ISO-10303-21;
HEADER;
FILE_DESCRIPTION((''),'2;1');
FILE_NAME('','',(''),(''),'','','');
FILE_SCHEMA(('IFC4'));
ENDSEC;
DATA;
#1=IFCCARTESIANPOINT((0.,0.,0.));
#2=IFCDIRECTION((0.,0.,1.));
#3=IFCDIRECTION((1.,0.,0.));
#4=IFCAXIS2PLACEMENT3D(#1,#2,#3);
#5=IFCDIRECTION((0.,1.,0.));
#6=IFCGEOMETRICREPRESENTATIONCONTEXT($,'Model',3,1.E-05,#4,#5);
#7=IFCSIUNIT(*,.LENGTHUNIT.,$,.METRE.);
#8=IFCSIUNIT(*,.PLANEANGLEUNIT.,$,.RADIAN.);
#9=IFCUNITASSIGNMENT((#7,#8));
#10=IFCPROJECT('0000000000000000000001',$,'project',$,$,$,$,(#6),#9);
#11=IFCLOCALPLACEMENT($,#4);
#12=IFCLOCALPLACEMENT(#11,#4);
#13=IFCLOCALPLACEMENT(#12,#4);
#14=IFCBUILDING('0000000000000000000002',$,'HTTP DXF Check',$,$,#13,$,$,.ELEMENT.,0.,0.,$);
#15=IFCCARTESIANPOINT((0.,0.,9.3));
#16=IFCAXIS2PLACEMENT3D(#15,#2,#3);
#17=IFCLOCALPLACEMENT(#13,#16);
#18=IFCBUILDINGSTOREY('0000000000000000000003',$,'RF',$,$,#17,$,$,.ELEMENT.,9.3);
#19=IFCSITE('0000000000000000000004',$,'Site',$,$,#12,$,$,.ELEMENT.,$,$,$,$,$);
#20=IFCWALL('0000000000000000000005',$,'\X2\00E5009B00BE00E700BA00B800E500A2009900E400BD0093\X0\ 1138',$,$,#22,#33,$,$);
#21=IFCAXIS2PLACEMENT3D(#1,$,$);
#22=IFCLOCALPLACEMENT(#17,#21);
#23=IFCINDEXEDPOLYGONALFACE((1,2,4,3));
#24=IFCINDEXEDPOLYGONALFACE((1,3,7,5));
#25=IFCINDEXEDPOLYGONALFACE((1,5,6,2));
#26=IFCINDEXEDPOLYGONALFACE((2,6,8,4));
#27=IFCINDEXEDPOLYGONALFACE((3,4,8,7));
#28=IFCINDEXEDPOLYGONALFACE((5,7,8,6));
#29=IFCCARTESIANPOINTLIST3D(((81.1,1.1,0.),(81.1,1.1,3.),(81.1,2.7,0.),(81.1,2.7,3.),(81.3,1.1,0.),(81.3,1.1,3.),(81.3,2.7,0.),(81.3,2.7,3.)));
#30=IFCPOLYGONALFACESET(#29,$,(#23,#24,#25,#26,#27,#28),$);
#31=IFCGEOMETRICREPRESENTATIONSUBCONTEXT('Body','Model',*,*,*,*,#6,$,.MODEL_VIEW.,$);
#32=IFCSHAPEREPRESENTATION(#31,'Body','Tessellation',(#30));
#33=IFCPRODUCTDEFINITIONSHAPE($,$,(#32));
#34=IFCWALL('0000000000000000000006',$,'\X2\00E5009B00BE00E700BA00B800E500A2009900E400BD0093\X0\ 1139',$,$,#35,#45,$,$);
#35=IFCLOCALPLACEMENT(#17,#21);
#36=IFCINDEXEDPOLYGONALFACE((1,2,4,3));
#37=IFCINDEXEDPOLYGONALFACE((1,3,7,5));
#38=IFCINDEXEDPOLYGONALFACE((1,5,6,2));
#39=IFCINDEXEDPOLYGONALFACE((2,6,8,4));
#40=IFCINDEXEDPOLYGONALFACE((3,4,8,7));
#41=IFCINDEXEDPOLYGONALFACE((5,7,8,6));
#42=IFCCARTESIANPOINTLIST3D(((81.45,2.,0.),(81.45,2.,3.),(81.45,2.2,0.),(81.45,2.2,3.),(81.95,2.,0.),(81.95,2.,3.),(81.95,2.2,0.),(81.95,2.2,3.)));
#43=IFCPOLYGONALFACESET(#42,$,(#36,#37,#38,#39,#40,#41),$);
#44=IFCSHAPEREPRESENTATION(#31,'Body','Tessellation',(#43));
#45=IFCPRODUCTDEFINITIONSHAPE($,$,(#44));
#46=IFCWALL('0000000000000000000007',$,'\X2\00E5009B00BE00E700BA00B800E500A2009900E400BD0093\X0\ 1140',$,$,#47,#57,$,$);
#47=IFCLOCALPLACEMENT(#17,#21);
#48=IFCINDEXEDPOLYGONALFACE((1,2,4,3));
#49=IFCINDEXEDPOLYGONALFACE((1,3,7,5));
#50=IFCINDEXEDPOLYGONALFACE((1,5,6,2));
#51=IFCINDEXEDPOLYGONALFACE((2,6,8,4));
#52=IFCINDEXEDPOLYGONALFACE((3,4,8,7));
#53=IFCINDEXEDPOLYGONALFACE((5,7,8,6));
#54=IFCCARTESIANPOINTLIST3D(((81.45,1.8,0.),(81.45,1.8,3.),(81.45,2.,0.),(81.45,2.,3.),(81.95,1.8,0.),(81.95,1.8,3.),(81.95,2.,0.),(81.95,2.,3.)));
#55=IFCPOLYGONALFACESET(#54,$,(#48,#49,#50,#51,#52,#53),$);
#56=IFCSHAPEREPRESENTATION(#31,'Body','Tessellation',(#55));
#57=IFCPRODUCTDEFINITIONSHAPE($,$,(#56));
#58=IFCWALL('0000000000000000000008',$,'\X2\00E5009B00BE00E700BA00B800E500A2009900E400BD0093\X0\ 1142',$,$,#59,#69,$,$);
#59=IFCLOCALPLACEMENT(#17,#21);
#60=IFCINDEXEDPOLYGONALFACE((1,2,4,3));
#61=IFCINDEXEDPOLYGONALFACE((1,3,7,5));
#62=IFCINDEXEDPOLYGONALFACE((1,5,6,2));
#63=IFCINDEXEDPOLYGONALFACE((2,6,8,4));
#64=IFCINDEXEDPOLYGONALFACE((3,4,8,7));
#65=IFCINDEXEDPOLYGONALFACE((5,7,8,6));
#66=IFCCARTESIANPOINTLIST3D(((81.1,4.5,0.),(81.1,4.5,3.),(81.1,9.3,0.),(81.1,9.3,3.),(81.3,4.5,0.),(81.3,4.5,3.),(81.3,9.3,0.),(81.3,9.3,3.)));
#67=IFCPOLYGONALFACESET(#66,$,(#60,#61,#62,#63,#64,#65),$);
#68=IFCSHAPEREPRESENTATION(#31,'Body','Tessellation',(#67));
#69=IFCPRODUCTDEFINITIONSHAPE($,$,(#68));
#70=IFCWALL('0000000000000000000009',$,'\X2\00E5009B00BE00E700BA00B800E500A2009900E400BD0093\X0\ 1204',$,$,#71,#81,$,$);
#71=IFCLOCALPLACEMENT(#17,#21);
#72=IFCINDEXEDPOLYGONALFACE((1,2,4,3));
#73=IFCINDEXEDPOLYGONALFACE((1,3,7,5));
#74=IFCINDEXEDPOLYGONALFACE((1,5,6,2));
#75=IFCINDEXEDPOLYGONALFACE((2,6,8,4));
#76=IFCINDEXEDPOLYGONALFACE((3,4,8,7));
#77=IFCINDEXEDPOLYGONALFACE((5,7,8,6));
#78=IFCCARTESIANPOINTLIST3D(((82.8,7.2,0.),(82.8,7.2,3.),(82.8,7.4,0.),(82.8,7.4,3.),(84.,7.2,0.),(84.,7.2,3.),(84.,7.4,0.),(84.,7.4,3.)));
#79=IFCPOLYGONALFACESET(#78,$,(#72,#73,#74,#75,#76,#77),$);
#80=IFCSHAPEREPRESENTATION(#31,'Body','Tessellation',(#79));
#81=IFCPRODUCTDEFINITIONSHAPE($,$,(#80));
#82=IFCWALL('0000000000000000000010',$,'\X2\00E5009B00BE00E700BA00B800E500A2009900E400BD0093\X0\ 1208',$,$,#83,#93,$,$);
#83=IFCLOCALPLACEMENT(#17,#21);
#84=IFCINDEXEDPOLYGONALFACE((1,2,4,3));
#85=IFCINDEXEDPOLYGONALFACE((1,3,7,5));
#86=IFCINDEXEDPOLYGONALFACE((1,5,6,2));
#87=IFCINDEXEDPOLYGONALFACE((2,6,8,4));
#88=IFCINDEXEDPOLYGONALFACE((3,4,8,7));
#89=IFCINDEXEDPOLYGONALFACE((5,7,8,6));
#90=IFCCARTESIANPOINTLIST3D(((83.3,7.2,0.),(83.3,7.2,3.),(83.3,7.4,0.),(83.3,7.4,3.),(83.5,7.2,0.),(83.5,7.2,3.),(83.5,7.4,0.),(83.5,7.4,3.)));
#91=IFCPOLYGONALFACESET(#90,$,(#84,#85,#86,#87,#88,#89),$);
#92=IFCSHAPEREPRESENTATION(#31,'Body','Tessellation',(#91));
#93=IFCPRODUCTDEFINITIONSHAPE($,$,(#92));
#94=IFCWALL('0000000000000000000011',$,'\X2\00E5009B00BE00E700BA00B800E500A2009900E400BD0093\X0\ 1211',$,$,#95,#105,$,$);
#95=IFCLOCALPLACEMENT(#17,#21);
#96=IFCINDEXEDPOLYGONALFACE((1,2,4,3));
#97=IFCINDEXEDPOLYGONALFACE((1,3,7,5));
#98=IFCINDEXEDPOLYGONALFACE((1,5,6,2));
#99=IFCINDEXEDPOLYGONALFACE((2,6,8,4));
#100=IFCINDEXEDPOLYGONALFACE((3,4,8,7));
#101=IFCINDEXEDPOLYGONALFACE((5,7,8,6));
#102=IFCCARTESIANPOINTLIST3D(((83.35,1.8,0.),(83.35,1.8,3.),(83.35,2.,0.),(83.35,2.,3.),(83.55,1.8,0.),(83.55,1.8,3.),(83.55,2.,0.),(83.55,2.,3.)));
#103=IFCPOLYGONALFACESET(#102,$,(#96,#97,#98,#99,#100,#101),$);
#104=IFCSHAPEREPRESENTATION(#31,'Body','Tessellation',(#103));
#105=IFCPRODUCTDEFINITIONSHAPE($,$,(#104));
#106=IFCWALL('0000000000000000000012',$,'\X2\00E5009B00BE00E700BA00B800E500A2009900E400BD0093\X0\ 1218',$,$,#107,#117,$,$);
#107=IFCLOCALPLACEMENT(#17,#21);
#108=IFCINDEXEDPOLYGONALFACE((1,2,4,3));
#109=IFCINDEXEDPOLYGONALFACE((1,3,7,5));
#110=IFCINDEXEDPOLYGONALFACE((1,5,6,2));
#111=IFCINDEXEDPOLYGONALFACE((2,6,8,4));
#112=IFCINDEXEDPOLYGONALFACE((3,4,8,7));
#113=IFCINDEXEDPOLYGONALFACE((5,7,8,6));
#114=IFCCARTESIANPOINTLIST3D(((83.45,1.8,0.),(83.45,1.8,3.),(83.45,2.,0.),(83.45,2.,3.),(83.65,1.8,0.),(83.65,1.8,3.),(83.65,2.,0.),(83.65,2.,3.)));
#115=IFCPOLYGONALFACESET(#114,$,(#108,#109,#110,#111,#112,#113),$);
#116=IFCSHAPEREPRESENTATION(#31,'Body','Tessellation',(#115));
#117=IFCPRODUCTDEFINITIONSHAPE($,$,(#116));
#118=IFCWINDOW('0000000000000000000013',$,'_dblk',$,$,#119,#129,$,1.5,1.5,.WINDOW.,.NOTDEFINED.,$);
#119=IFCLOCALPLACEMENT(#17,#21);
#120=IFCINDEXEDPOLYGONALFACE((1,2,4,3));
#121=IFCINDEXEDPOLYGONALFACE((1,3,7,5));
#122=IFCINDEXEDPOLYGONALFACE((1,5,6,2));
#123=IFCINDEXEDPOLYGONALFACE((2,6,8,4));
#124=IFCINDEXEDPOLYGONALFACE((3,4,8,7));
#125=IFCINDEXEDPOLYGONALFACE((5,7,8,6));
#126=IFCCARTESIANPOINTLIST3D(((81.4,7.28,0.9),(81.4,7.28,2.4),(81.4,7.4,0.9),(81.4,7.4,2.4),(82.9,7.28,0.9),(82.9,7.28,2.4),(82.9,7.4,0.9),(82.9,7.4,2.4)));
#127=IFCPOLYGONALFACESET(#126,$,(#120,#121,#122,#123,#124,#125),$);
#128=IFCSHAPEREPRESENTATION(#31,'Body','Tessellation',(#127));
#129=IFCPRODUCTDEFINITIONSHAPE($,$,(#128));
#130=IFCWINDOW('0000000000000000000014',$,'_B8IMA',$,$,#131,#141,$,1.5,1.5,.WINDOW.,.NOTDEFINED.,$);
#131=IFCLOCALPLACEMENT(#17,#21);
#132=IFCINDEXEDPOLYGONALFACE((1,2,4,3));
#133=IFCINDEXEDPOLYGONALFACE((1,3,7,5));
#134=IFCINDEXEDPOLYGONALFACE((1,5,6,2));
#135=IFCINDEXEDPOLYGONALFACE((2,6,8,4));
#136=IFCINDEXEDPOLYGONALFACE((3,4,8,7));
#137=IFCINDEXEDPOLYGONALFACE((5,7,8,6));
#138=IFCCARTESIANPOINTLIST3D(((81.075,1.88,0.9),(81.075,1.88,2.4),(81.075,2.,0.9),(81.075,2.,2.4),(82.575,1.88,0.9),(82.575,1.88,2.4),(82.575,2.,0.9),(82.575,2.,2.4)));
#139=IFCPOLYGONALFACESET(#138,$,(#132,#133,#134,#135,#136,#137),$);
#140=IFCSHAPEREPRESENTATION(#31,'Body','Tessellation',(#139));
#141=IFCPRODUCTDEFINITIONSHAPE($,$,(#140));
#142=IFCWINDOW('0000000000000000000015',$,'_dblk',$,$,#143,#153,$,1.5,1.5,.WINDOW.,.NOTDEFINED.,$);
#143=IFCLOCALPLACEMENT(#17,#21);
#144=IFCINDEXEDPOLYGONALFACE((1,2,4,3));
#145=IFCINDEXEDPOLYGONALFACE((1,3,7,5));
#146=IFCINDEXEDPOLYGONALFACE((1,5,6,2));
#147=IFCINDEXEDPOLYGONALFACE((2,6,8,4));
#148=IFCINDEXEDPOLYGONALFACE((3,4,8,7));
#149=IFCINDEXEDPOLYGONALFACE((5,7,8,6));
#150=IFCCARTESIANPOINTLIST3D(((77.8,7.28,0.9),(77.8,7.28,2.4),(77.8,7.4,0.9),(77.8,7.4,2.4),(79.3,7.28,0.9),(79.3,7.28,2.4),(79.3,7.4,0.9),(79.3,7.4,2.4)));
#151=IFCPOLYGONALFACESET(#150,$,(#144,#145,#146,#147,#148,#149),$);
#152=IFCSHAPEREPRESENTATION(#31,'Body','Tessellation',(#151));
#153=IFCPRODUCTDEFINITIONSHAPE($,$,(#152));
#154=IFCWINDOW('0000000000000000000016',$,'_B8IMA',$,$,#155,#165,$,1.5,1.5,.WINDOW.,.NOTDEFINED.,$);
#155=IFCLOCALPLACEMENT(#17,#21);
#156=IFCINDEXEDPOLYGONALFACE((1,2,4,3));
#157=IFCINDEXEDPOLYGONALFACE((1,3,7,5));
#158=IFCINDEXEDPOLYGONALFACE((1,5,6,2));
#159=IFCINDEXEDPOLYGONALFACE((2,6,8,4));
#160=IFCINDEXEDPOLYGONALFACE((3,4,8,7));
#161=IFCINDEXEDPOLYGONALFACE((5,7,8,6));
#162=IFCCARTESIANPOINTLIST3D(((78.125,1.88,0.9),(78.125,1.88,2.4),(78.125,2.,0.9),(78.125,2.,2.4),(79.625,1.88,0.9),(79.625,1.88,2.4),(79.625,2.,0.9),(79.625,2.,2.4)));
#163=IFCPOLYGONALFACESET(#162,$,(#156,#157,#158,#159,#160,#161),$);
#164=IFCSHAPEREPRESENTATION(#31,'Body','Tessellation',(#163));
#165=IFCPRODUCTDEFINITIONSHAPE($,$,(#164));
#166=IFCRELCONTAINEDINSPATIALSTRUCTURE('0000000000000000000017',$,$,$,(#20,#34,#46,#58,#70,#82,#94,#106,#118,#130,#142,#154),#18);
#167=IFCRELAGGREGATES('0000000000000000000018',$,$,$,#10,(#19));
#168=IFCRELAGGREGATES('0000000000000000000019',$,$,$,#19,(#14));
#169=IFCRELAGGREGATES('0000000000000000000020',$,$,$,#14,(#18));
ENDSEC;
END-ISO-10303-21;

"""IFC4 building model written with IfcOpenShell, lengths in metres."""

from ifc_helpers import new_model, si_unit, direction, frame, frame_2d, origin_with_axes, place, context, subcontext, project, spatial, rectangle, extrude, element, save


model = new_model("IFC4")

# Units and contexts
model_context = context("Model", 3, precision=1e-05, world=origin_with_axes(), true_north=direction((0.0, 1.0, 0.0)))
body_context = subcontext(model_context, "Body", "Model", "MODEL_VIEW")
ifc_project = project(units=[si_unit("LENGTHUNIT", "METRE"), si_unit("PLANEANGLEUNIT", "RADIAN")], contexts=[model_context])

# Site, building, storey
placement = place(None, origin_with_axes())
site_placement = place(placement, origin_with_axes())
site = spatial("IfcSite", under=ifc_project, at=site_placement, Name="Site", CompositionType="ELEMENT")
building_placement = place(site_placement, origin_with_axes())
building = spatial("IfcBuilding", under=site, at=building_placement, Name="HTTP DXF Check", CompositionType="ELEMENT", ElevationOfRefHeight=0.0, ElevationOfTerrain=0.0)
storey_placement = place(building_placement, frame((0.0, 0.0, 9.3), z_axis=(0.0, 0.0, 1.0), x_axis=(1.0, 0.0, 0.0)))
storey = spatial("IfcBuildingStorey", under=building, at=storey_placement, Name="RF", CompositionType="ELEMENT", Elevation=9.3)

# Walls
wall_1_placement = place(storey_placement, frame((81.2, 1.9, 0.0), z_axis=(0.0, 0.0, 1.0), x_axis=(0.0, -1.0, 0.0)))
element("IfcWall", 1, at=wall_1_placement, inside=storey, Name="å\u009b¾çº¸å¢\u0099ä½\u0093 1138", context=body_context, shape_type="SweptSolid", body=[
    extrude(rectangle(XDim=1.6, YDim=0.2, at=frame_2d((0.0, 0.0), x_axis=(1.0, 0.0, 0.0))), frame((0.0, 0.0, 0.0), z_axis=(0.0, 0.0, 1.0)), (0.0, 0.0, 1.0), 3.0),
])
for number, where, z_axis, x_axis, name in (
    (2, (81.7, 2.1, 0.0), (0.0, 0.0, 1.0), (-1.0, 0.0, 0.0), "å\u009b¾çº¸å¢\u0099ä½\u0093 1139"),
    (3, (81.7, 1.9, 0.0), (0.0, 0.0, 1.0), (-1.0, 0.0, 0.0), "å\u009b¾çº¸å¢\u0099ä½\u0093 1140"),
):
    element("IfcWall", number, at=place(storey_placement, frame(where, z_axis=z_axis, x_axis=x_axis)), inside=storey, Name=name, context=body_context, shape_type="SweptSolid", body=[
        extrude(rectangle(XDim=0.5, YDim=0.2, at=frame_2d((0.0, 0.0), x_axis=(1.0, 0.0, 0.0))), frame((0.0, 0.0, 0.0), z_axis=(0.0, 0.0, 1.0)), (0.0, 0.0, 1.0), 3.0),
    ])
wall_2_placement = place(storey_placement, frame((81.2, 6.9, 0.0), z_axis=(0.0, 0.0, 1.0), x_axis=(0.0, -1.0, 0.0)))
element("IfcWall", 4, at=wall_2_placement, inside=storey, Name="å\u009b¾çº¸å¢\u0099ä½\u0093 1142", context=body_context, shape_type="SweptSolid", body=[
    extrude(rectangle(XDim=4.8, YDim=0.2, at=frame_2d((0.0, 0.0), x_axis=(1.0, 0.0, 0.0))), frame((0.0, 0.0, 0.0), z_axis=(0.0, 0.0, 1.0)), (0.0, 0.0, 1.0), 3.0),
])
wall_3_placement = place(storey_placement, frame((83.4, 7.3, 0.0), z_axis=(0.0, 0.0, 1.0), x_axis=(1.0, 0.0, 0.0)))
element("IfcWall", 5, at=wall_3_placement, inside=storey, Name="å\u009b¾çº¸å¢\u0099ä½\u0093 1204", context=body_context, shape_type="SweptSolid", body=[
    extrude(rectangle(XDim=1.2, YDim=0.2, at=frame_2d((0.0, 0.0), x_axis=(1.0, 0.0, 0.0))), frame((0.0, 0.0, 0.0), z_axis=(0.0, 0.0, 1.0)), (0.0, 0.0, 1.0), 3.0),
])
for number, where, z_axis, x_axis, name in (
    (6, (83.4, 7.3, 0.0), (0.0, 0.0, 1.0), (0.0, 1.0, 0.0), "å\u009b¾çº¸å¢\u0099ä½\u0093 1208"),
    (7, (83.45, 1.9, 0.0), (0.0, 0.0, 1.0), (0.0, 1.0, 0.0), "å\u009b¾çº¸å¢\u0099ä½\u0093 1211"),
    (8, (83.55, 1.9, 0.0), (0.0, 0.0, 1.0), (0.0, -1.0, 0.0), "å\u009b¾çº¸å¢\u0099ä½\u0093 1218"),
):
    element("IfcWall", number, at=place(storey_placement, frame(where, z_axis=z_axis, x_axis=x_axis)), inside=storey, Name=name, context=body_context, shape_type="SweptSolid", body=[
        extrude(rectangle(XDim=0.2, YDim=0.2, at=frame_2d((0.0, 0.0), x_axis=(1.0, 0.0, 0.0))), frame((0.0, 0.0, 0.0), z_axis=(0.0, 0.0, 1.0)), (0.0, 0.0, 1.0), 3.0),
    ])

# Windows
for number, where, z_axis, x_axis, name in (
    (9, (82.15, 7.34, 0.9), (0.0, 0.0, 1.0), (1.0, 0.0, 0.0), "_dblk"),
    (10, (81.825, 1.94, 0.9), (0.0, 0.0, 1.0), (1.0, 0.0, 0.0), "_B8IMA"),
    (11, (78.55, 7.34, 0.9), (0.0, 0.0, 1.0), (1.0, 0.0, 0.0), "_dblk"),
    (12, (78.875, 1.94, 0.9), (0.0, 0.0, 1.0), (1.0, 0.0, 0.0), "_B8IMA"),
):
    element("IfcWindow", number, at=place(storey_placement, frame(where, z_axis=z_axis, x_axis=x_axis)), inside=storey, Name=name, OverallHeight=1.5, OverallWidth=1.5, PartitioningType="NOTDEFINED", PredefinedType="WINDOW", context=body_context, shape_type="SweptSolid", body=[
        extrude(rectangle(XDim=1.5, YDim=0.12, at=frame_2d((0.0, 0.0), x_axis=(1.0, 0.0, 0.0))), frame((0.0, 0.0, 0.0), z_axis=(0.0, 0.0, 1.0)), (0.0, 0.0, 1.0), 1.5),
    ])

save(model, "model.ifc")
